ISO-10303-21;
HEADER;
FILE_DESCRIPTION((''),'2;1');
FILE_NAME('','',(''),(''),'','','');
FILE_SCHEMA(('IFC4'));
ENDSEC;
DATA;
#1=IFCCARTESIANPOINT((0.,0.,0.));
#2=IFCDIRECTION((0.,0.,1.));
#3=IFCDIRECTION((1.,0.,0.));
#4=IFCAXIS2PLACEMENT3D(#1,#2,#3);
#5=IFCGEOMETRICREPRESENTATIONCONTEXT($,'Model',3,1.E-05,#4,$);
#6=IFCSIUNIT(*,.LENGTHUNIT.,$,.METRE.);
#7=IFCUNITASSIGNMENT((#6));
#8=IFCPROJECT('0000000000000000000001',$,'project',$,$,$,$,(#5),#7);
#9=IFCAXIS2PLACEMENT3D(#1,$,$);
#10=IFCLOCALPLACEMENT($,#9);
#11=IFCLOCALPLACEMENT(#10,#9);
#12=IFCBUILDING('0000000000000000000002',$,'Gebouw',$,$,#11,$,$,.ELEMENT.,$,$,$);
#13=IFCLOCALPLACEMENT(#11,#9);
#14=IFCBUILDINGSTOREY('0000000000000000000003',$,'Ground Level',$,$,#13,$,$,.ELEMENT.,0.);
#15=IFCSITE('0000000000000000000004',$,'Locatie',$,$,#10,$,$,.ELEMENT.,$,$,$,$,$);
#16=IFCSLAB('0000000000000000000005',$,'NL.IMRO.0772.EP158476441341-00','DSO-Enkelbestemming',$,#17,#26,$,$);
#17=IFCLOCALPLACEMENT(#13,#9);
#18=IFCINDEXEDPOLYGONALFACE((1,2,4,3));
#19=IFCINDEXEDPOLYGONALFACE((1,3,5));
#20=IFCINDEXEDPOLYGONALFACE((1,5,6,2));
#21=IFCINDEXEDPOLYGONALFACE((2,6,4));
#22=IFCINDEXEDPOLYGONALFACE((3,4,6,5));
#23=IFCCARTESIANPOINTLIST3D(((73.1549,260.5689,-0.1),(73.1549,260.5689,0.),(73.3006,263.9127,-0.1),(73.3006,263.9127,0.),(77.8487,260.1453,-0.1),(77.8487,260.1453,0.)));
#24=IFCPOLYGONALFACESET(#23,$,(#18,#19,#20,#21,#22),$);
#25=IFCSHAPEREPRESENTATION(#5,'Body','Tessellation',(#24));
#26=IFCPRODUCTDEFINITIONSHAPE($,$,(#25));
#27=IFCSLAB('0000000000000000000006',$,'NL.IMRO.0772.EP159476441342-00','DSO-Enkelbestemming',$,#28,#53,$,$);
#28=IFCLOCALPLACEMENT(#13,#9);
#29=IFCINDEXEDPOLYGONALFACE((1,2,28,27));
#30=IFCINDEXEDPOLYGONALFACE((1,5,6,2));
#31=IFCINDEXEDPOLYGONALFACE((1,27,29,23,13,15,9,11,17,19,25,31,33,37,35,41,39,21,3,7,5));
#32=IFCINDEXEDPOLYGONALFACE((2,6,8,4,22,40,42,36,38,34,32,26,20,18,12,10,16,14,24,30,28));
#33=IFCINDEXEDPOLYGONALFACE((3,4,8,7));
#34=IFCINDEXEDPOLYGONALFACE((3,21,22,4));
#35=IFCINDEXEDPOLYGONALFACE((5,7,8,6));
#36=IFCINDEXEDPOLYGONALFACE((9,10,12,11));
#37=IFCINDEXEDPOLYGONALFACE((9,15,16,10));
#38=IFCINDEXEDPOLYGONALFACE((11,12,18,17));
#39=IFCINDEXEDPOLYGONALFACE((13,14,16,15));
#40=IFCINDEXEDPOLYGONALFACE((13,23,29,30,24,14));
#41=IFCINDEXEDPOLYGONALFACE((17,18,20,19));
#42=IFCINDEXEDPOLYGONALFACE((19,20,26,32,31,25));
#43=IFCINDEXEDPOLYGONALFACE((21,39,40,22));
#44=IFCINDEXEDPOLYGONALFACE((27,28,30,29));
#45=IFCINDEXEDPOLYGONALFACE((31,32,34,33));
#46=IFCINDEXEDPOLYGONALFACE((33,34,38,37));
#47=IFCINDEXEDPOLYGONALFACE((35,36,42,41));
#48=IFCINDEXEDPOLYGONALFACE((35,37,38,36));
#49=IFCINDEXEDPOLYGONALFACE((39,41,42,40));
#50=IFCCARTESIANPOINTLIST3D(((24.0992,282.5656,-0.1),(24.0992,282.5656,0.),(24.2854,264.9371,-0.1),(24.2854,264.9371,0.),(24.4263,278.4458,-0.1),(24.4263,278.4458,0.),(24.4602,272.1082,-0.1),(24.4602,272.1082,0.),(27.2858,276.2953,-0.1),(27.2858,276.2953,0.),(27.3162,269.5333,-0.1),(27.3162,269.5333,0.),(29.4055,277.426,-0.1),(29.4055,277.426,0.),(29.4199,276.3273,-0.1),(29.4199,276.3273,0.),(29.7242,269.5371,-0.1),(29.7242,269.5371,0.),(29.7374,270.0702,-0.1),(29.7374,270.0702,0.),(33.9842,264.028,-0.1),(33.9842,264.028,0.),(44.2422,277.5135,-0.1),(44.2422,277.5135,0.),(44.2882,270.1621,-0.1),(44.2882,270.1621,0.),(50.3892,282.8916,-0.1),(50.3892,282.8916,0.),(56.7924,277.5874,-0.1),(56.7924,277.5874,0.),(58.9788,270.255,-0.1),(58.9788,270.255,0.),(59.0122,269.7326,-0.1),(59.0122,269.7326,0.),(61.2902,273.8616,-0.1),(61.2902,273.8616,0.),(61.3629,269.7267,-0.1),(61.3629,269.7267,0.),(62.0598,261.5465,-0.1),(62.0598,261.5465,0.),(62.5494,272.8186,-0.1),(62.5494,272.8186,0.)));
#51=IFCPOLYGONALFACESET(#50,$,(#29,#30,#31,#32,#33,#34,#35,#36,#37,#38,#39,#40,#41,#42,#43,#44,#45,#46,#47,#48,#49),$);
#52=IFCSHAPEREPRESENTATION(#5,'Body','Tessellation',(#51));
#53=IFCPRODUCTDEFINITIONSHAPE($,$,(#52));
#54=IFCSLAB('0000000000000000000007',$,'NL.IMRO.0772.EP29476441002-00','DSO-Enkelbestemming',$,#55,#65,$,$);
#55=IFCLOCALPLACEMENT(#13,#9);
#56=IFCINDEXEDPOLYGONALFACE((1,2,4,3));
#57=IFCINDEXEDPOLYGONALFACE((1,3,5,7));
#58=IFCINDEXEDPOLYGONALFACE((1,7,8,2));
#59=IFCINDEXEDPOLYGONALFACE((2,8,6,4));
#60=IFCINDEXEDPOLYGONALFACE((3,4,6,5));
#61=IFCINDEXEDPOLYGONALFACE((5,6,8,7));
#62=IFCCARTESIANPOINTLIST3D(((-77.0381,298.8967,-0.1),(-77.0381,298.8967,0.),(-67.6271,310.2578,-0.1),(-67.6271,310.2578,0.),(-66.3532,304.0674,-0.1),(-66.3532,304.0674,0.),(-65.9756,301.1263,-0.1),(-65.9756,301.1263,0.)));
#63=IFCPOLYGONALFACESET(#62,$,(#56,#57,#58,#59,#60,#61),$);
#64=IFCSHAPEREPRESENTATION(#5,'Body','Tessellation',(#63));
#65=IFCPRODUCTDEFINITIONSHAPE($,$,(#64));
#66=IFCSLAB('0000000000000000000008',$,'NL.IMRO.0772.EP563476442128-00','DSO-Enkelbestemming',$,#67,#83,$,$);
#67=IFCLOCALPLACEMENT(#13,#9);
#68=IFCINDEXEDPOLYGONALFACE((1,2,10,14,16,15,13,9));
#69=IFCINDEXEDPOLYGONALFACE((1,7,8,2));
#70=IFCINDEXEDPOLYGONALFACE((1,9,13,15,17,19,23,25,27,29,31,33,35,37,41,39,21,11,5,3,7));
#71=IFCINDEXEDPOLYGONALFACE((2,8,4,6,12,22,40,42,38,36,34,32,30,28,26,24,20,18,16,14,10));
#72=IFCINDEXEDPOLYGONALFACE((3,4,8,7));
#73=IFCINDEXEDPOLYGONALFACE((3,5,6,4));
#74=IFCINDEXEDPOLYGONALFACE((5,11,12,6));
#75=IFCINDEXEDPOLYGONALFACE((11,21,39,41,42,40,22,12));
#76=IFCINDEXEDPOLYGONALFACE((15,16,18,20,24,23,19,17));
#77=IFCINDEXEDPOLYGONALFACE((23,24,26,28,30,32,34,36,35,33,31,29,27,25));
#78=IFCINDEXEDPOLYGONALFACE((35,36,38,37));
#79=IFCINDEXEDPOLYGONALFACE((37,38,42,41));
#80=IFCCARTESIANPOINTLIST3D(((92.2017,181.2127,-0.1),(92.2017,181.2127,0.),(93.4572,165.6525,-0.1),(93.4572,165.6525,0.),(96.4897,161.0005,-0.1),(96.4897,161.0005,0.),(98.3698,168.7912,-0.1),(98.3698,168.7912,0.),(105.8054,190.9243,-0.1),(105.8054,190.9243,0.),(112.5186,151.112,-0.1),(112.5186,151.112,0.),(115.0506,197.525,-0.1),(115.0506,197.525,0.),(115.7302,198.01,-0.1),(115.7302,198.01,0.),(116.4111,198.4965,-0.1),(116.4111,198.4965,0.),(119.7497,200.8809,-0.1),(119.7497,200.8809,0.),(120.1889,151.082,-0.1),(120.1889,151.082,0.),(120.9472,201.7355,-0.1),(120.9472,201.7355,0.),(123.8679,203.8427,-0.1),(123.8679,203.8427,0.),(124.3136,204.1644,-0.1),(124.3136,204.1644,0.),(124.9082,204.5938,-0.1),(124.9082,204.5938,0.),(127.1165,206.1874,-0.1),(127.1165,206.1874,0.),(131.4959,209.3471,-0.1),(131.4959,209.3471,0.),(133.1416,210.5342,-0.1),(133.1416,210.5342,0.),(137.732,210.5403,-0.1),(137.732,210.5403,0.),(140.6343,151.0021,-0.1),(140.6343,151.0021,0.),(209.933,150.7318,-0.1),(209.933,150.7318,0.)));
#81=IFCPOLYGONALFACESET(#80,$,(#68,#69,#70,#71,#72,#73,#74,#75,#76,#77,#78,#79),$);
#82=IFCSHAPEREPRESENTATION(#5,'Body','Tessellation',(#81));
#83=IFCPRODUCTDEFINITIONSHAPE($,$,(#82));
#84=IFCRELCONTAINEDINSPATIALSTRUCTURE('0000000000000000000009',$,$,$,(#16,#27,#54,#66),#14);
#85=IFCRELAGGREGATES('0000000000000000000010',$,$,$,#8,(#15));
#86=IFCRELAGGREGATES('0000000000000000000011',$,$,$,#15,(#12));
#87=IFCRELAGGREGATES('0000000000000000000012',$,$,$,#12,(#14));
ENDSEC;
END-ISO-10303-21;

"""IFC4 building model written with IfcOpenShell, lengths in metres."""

from ifc_helpers import new_model, si_unit, frame, origin, origin_with_axes, place, context, project, spatial, polyline, outline, extrude, element, save


model = new_model("IFC4")

# Units and contexts
model_context = context("Model", 3, precision=1e-05, world=origin_with_axes())
ifc_project = project(units=[si_unit("LENGTHUNIT", "METRE")], contexts=[model_context])

# Site, building, storey
site_placement = place(None, origin())
site = spatial("IfcSite", under=ifc_project, at=site_placement, Name="Locatie", CompositionType="ELEMENT")
building_placement = place(site_placement, origin())
building = spatial("IfcBuilding", under=site, at=building_placement, Name="Gebouw", CompositionType="ELEMENT")
storey_placement = place(building_placement, origin())
storey = spatial("IfcBuildingStorey", under=building, at=storey_placement, Name="Ground Level", CompositionType="ELEMENT", Elevation=0.0)

# Slabs
slab_1_placement = place(storey_placement, origin())
element("IfcSlab", 1, at=slab_1_placement, inside=storey, Name="NL.IMRO.0772.EP158476441341-00", Description="DSO-Enkelbestemming", context=model_context, shape_type="SweptSolid", body=[
    extrude(outline(polyline([(73.1549, 260.5689), (73.3006, 263.9127), (77.8487, 260.1453), (73.1549, 260.5689)])), frame((0.0, 0.0, -0.1), z_axis=(0.0, 0.0, 1.0), x_axis=(1.0, 0.0, 0.0)), (0.0, 0.0, 1.0), 0.1),
])
slab_2_placement = place(storey_placement, origin())
element("IfcSlab", 2, at=slab_2_placement, inside=storey, Name="NL.IMRO.0772.EP159476441342-00", Description="DSO-Enkelbestemming", context=model_context, shape_type="SweptSolid", body=[
    extrude(outline(polyline([(62.0598, 261.5465), (33.9842, 264.028), (24.2854, 264.9371), (24.4602, 272.1082), (24.4263, 278.4458), (24.0992, 282.5656), (50.3892, 282.8916), (56.7924, 277.5874), (44.2422, 277.5135), (29.4055, 277.426), (29.4199, 276.3273), (27.2858, 276.2953), (27.3162, 269.5333), (29.7242, 269.5371), (29.7374, 270.0702), (44.2882, 270.1621), (58.9788, 270.255), (59.0122, 269.7326), (61.3629, 269.7267), (61.2902, 273.8616), (62.5494, 272.8186), (62.0598, 261.5465)])), frame((0.0, 0.0, -0.1), z_axis=(0.0, 0.0, 1.0), x_axis=(1.0, 0.0, 0.0)), (0.0, 0.0, 1.0), 0.1),
])
slab_3_placement = place(storey_placement, origin())
element("IfcSlab", 3, at=slab_3_placement, inside=storey, Name="NL.IMRO.0772.EP29476441002-00", Description="DSO-Enkelbestemming", context=model_context, shape_type="SweptSolid", body=[
    extrude(outline(polyline([(-66.3532, 304.0674), (-65.9756, 301.1263), (-77.0381, 298.8967), (-67.6271, 310.2578), (-66.3532, 304.0674)])), frame((0.0, 0.0, -0.1), z_axis=(0.0, 0.0, 1.0), x_axis=(1.0, 0.0, 0.0)), (0.0, 0.0, 1.0), 0.1),
])
slab_4_placement = place(storey_placement, origin())
element("IfcSlab", 4, at=slab_4_placement, inside=storey, Name="NL.IMRO.0772.EP563476442128-00", Description="DSO-Enkelbestemming", context=model_context, shape_type="SweptSolid", body=[
    extrude(outline(polyline([(140.6343, 151.0021), (120.1889, 151.082), (112.5186, 151.112), (96.4897, 161.0005), (93.4572, 165.6525), (98.3698, 168.7912), (92.2017, 181.2127), (105.8054, 190.9243), (115.0506, 197.525), (115.7302, 198.01), (116.4111, 198.4965), (119.7497, 200.8809), (120.9472, 201.7355), (123.8679, 203.8427), (124.3136, 204.1644), (124.9082, 204.5938), (127.1165, 206.1874), (131.4959, 209.3471), (133.1416, 210.5342), (137.732, 210.5403), (209.933, 150.7318), (140.6343, 151.0021)])), frame((0.0, 0.0, -0.1), z_axis=(0.0, 0.0, 1.0), x_axis=(1.0, 0.0, 0.0)), (0.0, 0.0, 1.0), 0.1),
])

save(model, "model.ifc")
